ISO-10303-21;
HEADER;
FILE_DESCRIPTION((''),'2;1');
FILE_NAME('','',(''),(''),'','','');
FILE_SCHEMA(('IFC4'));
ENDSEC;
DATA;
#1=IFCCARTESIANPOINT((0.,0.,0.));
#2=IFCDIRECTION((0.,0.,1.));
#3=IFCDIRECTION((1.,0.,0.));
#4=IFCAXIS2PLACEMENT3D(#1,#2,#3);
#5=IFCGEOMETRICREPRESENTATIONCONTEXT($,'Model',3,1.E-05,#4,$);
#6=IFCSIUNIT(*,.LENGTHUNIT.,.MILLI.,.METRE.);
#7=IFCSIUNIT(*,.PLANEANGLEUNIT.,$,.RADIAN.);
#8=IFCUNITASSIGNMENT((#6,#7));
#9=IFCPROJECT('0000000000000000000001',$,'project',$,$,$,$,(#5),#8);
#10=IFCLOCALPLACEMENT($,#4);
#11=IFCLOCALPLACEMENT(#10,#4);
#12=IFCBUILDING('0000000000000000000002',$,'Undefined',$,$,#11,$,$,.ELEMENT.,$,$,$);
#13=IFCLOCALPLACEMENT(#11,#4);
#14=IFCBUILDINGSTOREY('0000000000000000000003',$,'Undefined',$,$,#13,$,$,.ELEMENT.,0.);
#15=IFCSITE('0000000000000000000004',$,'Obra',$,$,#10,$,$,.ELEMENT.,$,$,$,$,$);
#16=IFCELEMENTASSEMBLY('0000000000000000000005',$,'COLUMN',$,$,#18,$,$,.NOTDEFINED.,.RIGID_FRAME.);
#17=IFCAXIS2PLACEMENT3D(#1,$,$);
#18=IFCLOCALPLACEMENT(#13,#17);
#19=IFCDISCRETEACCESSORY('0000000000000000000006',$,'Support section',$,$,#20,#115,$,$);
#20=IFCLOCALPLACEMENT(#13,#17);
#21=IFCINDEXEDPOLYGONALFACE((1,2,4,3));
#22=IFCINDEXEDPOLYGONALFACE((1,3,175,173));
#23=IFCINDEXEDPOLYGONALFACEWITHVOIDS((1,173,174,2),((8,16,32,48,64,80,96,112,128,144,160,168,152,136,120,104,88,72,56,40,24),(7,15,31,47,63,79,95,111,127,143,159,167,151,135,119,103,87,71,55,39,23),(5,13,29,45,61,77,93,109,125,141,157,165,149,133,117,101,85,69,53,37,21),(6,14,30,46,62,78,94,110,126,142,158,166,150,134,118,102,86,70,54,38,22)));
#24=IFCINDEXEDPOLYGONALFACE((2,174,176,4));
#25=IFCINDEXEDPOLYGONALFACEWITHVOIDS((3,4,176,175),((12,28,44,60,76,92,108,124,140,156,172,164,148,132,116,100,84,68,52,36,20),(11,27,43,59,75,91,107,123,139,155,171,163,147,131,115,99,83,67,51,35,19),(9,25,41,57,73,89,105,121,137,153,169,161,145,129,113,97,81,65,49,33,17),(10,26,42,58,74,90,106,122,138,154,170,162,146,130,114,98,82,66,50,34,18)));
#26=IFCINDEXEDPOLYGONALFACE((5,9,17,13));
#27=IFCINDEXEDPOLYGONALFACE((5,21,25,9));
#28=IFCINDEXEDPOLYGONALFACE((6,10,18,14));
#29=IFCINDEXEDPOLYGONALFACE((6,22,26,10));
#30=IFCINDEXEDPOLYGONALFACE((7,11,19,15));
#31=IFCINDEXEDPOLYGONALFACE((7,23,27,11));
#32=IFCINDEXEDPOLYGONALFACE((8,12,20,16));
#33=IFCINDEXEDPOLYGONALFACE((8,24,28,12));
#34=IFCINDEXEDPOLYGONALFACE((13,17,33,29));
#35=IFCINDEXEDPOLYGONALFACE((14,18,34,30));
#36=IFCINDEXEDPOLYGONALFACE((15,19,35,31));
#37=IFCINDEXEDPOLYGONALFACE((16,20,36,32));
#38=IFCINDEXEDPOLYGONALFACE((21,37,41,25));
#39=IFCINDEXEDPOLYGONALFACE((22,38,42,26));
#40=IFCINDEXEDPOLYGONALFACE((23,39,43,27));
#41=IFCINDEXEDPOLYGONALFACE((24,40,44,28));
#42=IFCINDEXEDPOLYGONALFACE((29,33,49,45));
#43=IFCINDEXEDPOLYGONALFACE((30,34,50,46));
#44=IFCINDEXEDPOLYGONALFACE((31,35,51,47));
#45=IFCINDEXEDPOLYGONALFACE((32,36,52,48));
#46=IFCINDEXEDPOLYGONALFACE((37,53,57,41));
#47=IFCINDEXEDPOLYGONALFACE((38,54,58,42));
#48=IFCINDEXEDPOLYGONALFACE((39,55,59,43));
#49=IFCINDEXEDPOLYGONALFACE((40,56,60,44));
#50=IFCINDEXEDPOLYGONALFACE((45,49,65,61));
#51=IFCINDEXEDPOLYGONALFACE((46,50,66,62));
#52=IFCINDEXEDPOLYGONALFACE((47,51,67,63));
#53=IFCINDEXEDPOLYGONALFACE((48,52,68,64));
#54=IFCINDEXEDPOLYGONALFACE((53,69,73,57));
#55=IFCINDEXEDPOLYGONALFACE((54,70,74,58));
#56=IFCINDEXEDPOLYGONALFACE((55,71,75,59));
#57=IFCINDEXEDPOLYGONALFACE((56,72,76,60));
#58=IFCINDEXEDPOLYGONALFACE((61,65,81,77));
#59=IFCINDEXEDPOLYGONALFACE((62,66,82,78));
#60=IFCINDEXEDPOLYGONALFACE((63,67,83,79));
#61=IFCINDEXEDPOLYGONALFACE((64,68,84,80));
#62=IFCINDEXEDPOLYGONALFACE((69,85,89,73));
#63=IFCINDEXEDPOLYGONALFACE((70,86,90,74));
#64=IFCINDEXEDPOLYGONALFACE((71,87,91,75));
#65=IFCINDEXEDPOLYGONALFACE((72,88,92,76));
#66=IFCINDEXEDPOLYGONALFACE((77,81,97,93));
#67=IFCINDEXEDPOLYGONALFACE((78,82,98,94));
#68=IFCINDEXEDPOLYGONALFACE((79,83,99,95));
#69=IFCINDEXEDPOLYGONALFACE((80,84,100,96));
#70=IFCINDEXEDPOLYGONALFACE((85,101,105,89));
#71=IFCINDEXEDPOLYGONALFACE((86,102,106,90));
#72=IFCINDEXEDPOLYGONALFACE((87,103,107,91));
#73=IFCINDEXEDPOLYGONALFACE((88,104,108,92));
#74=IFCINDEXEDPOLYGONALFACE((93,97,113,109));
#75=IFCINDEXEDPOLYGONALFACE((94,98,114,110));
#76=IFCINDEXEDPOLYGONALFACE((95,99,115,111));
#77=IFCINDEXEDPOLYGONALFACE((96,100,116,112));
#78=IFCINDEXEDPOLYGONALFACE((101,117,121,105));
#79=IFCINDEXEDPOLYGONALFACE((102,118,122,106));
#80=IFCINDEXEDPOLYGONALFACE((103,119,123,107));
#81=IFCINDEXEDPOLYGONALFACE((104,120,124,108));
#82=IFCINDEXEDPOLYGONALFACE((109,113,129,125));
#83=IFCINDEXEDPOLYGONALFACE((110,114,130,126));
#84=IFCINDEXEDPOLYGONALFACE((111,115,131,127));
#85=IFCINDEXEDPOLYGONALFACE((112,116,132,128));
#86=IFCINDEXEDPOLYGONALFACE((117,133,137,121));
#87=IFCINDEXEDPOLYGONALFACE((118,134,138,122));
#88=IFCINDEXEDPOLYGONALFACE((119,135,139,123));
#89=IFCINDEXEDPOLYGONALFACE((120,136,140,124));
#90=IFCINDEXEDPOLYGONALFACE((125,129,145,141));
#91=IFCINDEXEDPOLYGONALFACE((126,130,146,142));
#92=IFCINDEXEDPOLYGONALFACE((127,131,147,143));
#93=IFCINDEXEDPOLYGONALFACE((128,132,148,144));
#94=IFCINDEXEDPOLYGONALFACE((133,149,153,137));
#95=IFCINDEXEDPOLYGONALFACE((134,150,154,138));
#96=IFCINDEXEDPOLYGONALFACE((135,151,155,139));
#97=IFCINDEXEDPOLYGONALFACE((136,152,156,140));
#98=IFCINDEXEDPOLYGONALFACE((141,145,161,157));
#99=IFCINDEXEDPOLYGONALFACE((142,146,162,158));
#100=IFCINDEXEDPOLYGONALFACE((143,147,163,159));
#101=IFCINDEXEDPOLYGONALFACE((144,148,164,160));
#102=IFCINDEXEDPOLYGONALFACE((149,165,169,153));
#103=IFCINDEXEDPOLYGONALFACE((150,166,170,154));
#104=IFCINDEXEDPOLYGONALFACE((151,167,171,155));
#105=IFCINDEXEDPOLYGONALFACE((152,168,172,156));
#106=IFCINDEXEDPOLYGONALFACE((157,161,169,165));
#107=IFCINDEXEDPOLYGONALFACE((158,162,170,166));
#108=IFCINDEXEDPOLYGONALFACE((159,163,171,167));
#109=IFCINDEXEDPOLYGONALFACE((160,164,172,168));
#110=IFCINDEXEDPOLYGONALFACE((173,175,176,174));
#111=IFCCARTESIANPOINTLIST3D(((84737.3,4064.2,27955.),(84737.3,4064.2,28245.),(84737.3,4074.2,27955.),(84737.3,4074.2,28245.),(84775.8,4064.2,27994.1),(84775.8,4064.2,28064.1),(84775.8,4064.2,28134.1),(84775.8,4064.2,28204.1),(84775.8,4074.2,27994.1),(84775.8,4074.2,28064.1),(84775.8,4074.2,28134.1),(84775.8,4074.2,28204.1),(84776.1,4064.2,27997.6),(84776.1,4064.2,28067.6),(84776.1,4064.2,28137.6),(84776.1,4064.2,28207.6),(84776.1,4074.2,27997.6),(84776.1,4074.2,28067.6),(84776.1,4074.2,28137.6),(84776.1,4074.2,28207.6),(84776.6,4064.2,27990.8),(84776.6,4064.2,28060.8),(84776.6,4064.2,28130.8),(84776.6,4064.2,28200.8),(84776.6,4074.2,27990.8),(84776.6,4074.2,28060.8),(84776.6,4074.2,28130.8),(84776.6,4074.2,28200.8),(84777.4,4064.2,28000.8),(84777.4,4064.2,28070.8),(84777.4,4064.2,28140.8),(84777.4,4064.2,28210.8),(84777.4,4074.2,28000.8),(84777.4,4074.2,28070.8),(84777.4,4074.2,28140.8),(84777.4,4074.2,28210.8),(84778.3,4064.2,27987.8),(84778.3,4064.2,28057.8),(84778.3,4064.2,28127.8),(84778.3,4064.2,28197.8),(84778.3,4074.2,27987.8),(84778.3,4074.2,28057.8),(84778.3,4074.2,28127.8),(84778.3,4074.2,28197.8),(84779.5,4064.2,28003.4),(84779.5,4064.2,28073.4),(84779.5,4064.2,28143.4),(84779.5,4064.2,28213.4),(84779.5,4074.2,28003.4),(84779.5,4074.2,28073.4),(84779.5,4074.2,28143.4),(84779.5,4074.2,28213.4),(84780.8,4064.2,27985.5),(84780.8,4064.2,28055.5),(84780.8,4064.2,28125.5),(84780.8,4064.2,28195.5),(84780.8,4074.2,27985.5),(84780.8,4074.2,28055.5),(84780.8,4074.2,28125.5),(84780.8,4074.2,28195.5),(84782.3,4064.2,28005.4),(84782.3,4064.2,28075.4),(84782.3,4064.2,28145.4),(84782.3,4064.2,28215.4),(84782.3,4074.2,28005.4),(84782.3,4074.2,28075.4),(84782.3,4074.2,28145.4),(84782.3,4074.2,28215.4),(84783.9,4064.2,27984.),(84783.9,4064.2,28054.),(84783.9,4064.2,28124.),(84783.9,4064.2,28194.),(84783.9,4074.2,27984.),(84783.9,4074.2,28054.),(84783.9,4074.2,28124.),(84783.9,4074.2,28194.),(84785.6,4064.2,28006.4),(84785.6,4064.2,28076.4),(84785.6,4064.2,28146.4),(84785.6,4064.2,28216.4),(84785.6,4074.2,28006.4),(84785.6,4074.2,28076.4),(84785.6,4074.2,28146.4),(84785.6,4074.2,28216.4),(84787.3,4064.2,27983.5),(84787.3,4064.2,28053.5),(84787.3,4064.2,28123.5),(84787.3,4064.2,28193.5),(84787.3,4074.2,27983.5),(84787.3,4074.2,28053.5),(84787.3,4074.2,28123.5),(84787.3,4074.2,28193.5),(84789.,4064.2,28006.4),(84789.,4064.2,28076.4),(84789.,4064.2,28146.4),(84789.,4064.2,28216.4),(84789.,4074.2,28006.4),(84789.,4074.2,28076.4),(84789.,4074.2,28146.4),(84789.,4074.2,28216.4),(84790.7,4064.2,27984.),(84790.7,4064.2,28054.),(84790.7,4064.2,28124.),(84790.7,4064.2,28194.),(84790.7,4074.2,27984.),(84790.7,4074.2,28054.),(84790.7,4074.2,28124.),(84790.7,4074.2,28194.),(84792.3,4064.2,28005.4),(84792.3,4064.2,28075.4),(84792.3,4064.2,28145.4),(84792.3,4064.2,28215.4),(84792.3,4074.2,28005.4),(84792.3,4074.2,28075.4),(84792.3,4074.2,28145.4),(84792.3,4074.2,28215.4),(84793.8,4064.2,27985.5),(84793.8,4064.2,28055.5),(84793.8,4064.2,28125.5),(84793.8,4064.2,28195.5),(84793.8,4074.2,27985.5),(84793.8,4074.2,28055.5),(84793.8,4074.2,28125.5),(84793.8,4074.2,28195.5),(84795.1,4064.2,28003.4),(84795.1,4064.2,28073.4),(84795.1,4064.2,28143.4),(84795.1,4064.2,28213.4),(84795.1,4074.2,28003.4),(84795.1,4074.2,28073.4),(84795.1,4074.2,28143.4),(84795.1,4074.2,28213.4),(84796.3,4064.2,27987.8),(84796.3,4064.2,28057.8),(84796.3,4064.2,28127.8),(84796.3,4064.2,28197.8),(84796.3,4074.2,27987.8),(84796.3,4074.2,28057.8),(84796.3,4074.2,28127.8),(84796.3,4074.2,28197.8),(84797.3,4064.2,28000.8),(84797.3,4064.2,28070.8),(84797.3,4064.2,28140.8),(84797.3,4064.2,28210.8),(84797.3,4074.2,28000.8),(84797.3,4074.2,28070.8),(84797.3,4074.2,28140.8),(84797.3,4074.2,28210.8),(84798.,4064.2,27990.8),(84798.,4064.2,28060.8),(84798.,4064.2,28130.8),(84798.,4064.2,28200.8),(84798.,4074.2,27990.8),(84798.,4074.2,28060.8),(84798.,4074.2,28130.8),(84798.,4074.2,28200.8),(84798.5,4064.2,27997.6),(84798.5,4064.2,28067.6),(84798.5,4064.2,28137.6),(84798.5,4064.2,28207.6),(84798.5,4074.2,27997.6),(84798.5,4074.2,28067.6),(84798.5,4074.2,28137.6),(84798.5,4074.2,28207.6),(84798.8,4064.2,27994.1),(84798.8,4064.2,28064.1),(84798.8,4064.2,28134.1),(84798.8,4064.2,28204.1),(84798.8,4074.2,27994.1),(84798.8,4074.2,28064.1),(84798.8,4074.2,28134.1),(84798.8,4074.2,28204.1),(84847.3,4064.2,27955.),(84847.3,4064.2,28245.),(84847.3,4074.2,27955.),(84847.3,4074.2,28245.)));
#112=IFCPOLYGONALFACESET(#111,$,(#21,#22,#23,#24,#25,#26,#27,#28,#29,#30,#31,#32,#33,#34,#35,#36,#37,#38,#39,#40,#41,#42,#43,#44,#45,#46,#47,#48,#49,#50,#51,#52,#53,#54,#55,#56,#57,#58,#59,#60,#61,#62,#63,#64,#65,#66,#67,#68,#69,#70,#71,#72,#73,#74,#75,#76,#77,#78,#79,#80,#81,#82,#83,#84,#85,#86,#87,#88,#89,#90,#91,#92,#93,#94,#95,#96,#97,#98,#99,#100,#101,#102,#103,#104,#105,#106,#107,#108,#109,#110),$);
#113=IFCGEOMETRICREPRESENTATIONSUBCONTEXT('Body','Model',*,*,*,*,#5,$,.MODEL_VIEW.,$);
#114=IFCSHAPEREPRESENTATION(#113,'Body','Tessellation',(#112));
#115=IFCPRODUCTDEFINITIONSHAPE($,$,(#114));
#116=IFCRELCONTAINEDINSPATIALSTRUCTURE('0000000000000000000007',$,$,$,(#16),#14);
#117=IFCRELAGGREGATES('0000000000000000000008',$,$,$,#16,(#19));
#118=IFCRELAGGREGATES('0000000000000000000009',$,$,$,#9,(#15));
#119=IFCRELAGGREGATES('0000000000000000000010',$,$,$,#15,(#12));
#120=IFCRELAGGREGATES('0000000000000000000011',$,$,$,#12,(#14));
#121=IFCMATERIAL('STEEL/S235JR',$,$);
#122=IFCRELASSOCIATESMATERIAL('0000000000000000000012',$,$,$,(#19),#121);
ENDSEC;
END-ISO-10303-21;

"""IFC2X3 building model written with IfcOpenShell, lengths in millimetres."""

from ifc_helpers import new_model, si_unit, frame, origin_with_axes, origin_2d_with_axis, place, context, subcontext, project, spatial, rectangle, circle, extrude, source, transform, mapped, material, element, aggregate, save


model = new_model("IFC2X3")

# Units and contexts
model_context = context("Model", 3, precision=1e-05, world=origin_with_axes())
body_context = subcontext(model_context, "Body", "Model", "MODEL_VIEW")
ifc_project = project(units=[si_unit("LENGTHUNIT", "METRE", prefix="MILLI"), si_unit("PLANEANGLEUNIT", "RADIAN")], contexts=[model_context])

# Site, building, storey
site_placement = place(None, origin_with_axes())
site = spatial("IfcSite", under=ifc_project, at=site_placement, Name="Obra", CompositionType="ELEMENT")
building_placement = place(site_placement, origin_with_axes())
building = spatial("IfcBuilding", under=site, at=building_placement, Name="Undefined", CompositionType="ELEMENT")
storey_placement = place(building_placement, origin_with_axes())
storey = spatial("IfcBuildingStorey", under=building, at=storey_placement, Name="Undefined", CompositionType="ELEMENT", Elevation=0.0)

# Element assembly
assembly_1_placement = place(storey_placement, origin_with_axes())
assembly_1 = element("IfcElementAssembly", 1, at=assembly_1_placement, inside=storey, Name="COLUMN", AssemblyPlace="NOTDEFINED", PredefinedType="RIGID_FRAME")
ifc_material = material(Name="STEEL/S235JR")

# Discrete accessory, opening
discrete_accessory_1_placement = place(assembly_1_placement, frame((84792.3, 4069.2, 27955.0), z_axis=(0.0, 0.0, 1.0), x_axis=(1.0, 0.0, 0.0)))
discrete_accessory_1 = element("IfcDiscreteAccessory", 2, at=discrete_accessory_1_placement, material=ifc_material, Name="Support section", context=body_context, shape_type="SweptSolid", body=[
    extrude(rectangle(XDim=10.0, YDim=110.0, at=origin_2d_with_axis()), frame((0.0, 0.0, 290.0), z_axis=(0.0, 0.0, -1.0), x_axis=(0.0, 1.0, 0.0)), (0.0, 0.0, 1.0), 290.0),
])
shared_shape_1 = source(origin_with_axes(), body_context, "Body", "SweptSolid", [
    extrude(circle(Radius=11.5, at=origin_2d_with_axis()), frame((0.0, -14.4, 0.0), z_axis=(0.0, 1.0, 0.0), x_axis=(1.0, 0.0, 0.0)), (0.0, 0.0, 1.0), 10.2),
])
opening_1_placement = place(assembly_1_placement, frame((84837.3, 4059.9, 28300.0), z_axis=(-1.0, 0.0, 0.0), x_axis=(0.0, 0.0, -1.0)))
element("IfcOpeningElement", 3, at=opening_1_placement, cuts=discrete_accessory_1, ObjectType="Opening", context=body_context, shape_type="MappedRepresentation", body=[
    mapped(shared_shape_1, transform((95.0, 0.0, 50.0))),
    mapped(shared_shape_1, transform((165.0, 0.0, 50.0))),
    mapped(shared_shape_1, transform((235.0, 0.0, 50.0))),
    mapped(shared_shape_1, transform((305.0, 0.0, 50.0))),
])
aggregate(assembly_1, [discrete_accessory_1])

save(model, "model.ifc")
